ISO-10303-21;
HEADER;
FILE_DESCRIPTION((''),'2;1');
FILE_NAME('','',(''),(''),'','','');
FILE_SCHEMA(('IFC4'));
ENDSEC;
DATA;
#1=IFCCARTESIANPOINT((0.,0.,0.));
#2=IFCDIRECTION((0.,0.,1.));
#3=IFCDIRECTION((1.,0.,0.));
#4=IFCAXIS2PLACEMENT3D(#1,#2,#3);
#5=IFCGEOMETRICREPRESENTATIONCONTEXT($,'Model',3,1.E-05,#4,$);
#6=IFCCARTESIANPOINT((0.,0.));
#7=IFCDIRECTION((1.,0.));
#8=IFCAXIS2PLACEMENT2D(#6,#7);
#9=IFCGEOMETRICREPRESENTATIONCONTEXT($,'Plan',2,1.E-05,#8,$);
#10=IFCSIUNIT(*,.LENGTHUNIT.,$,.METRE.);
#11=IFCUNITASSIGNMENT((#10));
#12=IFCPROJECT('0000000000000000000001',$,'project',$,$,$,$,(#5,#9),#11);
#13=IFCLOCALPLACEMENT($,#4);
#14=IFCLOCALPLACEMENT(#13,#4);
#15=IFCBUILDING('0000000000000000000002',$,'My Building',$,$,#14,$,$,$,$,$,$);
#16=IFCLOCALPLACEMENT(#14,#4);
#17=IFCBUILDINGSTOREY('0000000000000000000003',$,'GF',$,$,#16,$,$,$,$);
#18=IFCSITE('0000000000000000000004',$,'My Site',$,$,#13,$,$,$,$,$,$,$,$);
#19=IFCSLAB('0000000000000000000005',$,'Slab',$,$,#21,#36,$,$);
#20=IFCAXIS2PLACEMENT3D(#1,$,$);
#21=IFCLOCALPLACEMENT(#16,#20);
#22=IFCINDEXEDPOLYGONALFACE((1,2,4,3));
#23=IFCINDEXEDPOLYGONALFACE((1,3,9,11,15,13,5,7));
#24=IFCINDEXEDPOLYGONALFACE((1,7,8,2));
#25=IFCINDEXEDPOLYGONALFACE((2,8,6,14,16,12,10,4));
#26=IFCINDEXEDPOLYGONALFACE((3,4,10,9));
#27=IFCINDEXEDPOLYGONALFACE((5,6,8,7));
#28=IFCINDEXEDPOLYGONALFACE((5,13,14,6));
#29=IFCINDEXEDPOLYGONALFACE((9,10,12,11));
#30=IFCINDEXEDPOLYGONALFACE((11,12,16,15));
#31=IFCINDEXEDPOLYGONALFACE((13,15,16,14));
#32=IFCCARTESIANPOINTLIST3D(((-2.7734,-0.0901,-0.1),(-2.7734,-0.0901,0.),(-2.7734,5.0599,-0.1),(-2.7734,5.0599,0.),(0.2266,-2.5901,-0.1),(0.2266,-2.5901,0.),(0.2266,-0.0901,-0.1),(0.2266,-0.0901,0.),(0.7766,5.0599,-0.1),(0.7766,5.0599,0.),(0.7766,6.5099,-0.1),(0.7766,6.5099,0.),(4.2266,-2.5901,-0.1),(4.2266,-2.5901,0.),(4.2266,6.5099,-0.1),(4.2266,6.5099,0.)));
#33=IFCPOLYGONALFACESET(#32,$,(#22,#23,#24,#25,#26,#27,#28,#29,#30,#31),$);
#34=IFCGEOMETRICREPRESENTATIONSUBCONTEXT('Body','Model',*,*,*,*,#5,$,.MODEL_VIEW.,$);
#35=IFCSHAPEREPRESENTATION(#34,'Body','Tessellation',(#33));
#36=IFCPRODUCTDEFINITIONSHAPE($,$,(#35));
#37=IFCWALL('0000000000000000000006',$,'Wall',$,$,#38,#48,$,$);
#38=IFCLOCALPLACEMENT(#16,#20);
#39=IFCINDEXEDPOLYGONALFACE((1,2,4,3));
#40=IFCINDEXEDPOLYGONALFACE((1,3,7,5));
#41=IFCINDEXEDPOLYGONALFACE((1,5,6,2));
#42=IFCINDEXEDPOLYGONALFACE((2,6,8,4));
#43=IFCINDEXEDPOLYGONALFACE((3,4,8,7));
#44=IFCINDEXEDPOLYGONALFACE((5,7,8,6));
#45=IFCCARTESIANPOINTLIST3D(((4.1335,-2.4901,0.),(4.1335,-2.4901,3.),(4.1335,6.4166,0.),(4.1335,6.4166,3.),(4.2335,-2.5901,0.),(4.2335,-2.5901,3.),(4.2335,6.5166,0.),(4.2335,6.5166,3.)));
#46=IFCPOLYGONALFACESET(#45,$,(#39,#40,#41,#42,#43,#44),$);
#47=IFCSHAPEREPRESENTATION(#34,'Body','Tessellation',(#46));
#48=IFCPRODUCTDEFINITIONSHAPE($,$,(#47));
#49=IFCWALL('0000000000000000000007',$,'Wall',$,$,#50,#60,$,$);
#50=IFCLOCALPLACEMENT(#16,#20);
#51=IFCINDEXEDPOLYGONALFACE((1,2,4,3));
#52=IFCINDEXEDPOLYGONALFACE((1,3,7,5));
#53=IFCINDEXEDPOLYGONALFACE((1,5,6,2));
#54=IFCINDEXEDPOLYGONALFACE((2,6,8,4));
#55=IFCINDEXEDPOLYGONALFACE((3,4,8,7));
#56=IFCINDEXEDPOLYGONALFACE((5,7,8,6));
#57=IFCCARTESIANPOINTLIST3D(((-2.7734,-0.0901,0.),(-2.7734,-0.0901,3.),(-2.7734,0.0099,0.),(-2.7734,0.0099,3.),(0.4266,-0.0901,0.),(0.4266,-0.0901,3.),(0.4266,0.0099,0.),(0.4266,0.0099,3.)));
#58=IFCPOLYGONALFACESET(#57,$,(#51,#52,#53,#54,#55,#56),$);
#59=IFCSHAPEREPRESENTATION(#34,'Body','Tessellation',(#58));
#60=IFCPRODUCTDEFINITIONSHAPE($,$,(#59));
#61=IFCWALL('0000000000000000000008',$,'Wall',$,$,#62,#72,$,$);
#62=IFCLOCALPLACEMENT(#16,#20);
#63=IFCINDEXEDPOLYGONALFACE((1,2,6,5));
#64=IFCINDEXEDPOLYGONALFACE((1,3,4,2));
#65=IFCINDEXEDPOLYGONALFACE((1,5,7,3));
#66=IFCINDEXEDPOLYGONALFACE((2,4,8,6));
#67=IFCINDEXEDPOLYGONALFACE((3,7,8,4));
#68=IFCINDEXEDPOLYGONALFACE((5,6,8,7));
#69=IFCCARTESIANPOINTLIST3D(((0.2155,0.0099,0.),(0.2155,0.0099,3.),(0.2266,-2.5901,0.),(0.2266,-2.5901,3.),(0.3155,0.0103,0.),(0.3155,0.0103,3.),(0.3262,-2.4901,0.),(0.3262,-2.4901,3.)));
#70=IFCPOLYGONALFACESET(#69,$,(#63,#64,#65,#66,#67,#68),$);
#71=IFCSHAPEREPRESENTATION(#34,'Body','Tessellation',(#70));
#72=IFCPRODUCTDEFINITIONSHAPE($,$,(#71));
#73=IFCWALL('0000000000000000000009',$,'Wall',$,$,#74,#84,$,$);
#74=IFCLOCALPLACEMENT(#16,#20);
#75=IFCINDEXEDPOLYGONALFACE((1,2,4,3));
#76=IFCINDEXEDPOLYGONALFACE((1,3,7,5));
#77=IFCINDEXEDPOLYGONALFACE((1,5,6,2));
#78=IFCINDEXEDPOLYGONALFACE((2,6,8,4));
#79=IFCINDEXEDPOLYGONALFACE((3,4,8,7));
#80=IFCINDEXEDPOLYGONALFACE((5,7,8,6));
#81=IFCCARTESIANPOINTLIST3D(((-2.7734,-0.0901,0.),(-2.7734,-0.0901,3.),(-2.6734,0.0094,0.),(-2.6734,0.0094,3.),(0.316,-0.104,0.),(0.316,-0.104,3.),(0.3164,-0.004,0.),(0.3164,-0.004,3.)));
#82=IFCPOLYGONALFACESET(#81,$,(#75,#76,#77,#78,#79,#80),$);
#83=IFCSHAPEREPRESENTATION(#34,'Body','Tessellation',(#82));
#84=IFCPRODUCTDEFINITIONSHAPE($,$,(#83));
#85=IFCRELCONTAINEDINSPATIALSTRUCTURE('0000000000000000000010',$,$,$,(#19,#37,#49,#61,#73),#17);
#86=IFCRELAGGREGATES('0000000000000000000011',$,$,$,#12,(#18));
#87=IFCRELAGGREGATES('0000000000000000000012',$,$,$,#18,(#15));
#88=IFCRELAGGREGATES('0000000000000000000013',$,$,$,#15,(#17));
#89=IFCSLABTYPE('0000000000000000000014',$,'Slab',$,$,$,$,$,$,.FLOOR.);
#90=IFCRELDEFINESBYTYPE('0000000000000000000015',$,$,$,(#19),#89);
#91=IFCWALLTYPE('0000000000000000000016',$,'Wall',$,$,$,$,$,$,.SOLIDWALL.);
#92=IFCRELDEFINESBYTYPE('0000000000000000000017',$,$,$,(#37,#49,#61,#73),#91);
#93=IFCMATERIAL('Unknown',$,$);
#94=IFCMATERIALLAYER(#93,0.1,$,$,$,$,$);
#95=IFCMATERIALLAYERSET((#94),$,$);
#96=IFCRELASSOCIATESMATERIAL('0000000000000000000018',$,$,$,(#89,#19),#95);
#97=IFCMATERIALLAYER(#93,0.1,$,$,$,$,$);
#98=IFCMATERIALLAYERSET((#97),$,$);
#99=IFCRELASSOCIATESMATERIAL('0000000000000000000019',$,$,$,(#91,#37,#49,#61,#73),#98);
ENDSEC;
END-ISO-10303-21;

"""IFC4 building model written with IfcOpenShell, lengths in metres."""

from ifc_helpers import new_model, si_unit, frame, origin_with_axes, origin_2d_with_axis, place, context, subcontext, project, spatial, line, indexed_curve, outline, extrude, material, layer, layer_set, layer_usage, type_object, element, save


model = new_model("IFC4")

# Units and contexts
model_context = context("Model", 3, precision=1e-05, world=origin_with_axes())
plan_context = context("Plan", 2, precision=1e-05, world=origin_2d_with_axis())
body_context_1 = subcontext(model_context, "Body", "Model", "MODEL_VIEW")
ifc_project = project(units=[si_unit("LENGTHUNIT", "METRE")], contexts=[model_context, plan_context])

# Site, building, storey
site_placement = place(None, origin_with_axes())
site = spatial("IfcSite", under=ifc_project, at=site_placement, Name="My Site")
building_placement = place(site_placement, origin_with_axes())
building = spatial("IfcBuilding", under=site, at=building_placement, Name="My Building")
storey_placement = place(building_placement, origin_with_axes())
storey = spatial("IfcBuildingStorey", under=building, at=storey_placement, Name="GF")

# Slab
ifc_material = material(Name="Unknown")
ifc_layer_1 = layer(ifc_material, 0.1)
ifc_layer_set_1 = layer_set([ifc_layer_1])
ifc_layer_usage_1 = layer_usage(ifc_layer_set_1, "AXIS3", "POSITIVE", -0.1)
slab_type = type_object("IfcSlabType", Name="Slab", PredefinedType="FLOOR", material=ifc_layer_set_1)
slab_placement = place(storey_placement, frame((4.2266, -2.5901, 0.0), z_axis=(0.0, 0.0, 1.0), x_axis=(1.0, 0.0, 0.0)))
element("IfcSlab", 1, at=slab_placement, inside=storey, type_object=slab_type, material=ifc_layer_usage_1, Name="Slab", context=body_context_1, shape_type="SweptSolid", body=[
    extrude(outline(indexed_curve([(0.0, 0.0), (0.0, 9.1), (-3.45, 9.1), (-3.45, 7.65), (-7.0, 7.65), (-7.0, 2.5), (-4.0, 2.5), (-4.0, 0.0), (0.0, 0.0)])), frame((0.0, 0.0, -0.1), z_axis=(0.0, 0.0, 1.0), x_axis=(1.0, 0.0, 0.0)), (0.0, 0.0, 1.0), 0.1),
])

# Shared definitions
ifc_layer_2 = layer(ifc_material, 0.1)
ifc_layer_set_2 = layer_set([ifc_layer_2])
wall_type = type_object("IfcWallType", Name="Wall", PredefinedType="SOLIDWALL", material=ifc_layer_set_2)

# Walls
ifc_layer_usage_2 = layer_usage(ifc_layer_set_2, "AXIS2", "POSITIVE", 0.0)
wall_1_placement = place(storey_placement, frame((4.2335, -2.5901, 0.0), z_axis=(0.0, 0.0, 1.0), x_axis=(0.0, 1.0, 0.0)))
element("IfcWall", 2, at=wall_1_placement, inside=storey, type_object=wall_type, material=ifc_layer_usage_2, Name="Wall", context=body_context_1, shape_type="SweptSolid", body=[
    extrude(outline(indexed_curve([(0.0, 0.0), (0.1, 0.1), (9.0067, 0.1), (9.1067, 0.0)], segments=[line(1, 2, 3, 4, 1)])), origin_with_axes(), (0.0, 0.0, 1.0), 3.0),
])
ifc_layer_usage_3 = layer_usage(ifc_layer_set_2, "AXIS2", "POSITIVE", 0.0)
wall_2_placement = place(storey_placement, frame((-2.7734, -0.0901, 0.0), z_axis=(0.0, 0.0, 1.0), x_axis=(1.0, 0.0, 0.0)))
element("IfcWall", 3, at=wall_2_placement, inside=storey, type_object=wall_type, material=ifc_layer_usage_3, Name="Wall", context=body_context_1, shape_type="SweptSolid", body=[
    extrude(outline(indexed_curve([(0.0, 0.0), (0.0, 0.1), (3.2, 0.1), (3.2, 0.0)], segments=[line(1, 2, 3, 4, 1)])), origin_with_axes(), (0.0, 0.0, 1.0), 3.0),
])
ifc_layer_usage_4 = layer_usage(ifc_layer_set_2, "AXIS2", "POSITIVE", 0.0)
wall_3_placement = place(storey_placement, frame((0.2155, 0.0099, 0.0), z_axis=(0.0, 0.0, 1.0), x_axis=(0.004272, -0.999991, 0.0)))
element("IfcWall", 4, at=wall_3_placement, inside=storey, type_object=wall_type, material=ifc_layer_usage_4, Name="Wall", context=body_context_1, shape_type="SweptSolid", body=[
    extrude(outline(indexed_curve([(0.0, 0.0), (0.0, 0.1), (2.5005, 0.1), (2.6, 0.0)], segments=[line(1, 2, 3, 4, 1)])), origin_with_axes(), (0.0, 0.0, 1.0), 3.0),
])
ifc_layer_usage_5 = layer_usage(ifc_layer_set_2, "AXIS2", "POSITIVE", 0.0)
wall_4_placement = place(storey_placement, frame((-2.7734, -0.0901, 0.0), z_axis=(0.0, 0.0, 1.0), x_axis=(0.99999, -0.004496, 0.0)))
element("IfcWall", 5, at=wall_4_placement, inside=storey, type_object=wall_type, material=ifc_layer_usage_5, Name="Wall", context=body_context_1, shape_type="SweptSolid", body=[
    extrude(outline(indexed_curve([(0.0, 0.0), (0.0996, 0.1), (3.0894, 0.1), (3.0894, 0.0)], segments=[line(1, 2, 3, 4, 1)])), origin_with_axes(), (0.0, 0.0, 1.0), 3.0),
])

save(model, "model.ifc")
